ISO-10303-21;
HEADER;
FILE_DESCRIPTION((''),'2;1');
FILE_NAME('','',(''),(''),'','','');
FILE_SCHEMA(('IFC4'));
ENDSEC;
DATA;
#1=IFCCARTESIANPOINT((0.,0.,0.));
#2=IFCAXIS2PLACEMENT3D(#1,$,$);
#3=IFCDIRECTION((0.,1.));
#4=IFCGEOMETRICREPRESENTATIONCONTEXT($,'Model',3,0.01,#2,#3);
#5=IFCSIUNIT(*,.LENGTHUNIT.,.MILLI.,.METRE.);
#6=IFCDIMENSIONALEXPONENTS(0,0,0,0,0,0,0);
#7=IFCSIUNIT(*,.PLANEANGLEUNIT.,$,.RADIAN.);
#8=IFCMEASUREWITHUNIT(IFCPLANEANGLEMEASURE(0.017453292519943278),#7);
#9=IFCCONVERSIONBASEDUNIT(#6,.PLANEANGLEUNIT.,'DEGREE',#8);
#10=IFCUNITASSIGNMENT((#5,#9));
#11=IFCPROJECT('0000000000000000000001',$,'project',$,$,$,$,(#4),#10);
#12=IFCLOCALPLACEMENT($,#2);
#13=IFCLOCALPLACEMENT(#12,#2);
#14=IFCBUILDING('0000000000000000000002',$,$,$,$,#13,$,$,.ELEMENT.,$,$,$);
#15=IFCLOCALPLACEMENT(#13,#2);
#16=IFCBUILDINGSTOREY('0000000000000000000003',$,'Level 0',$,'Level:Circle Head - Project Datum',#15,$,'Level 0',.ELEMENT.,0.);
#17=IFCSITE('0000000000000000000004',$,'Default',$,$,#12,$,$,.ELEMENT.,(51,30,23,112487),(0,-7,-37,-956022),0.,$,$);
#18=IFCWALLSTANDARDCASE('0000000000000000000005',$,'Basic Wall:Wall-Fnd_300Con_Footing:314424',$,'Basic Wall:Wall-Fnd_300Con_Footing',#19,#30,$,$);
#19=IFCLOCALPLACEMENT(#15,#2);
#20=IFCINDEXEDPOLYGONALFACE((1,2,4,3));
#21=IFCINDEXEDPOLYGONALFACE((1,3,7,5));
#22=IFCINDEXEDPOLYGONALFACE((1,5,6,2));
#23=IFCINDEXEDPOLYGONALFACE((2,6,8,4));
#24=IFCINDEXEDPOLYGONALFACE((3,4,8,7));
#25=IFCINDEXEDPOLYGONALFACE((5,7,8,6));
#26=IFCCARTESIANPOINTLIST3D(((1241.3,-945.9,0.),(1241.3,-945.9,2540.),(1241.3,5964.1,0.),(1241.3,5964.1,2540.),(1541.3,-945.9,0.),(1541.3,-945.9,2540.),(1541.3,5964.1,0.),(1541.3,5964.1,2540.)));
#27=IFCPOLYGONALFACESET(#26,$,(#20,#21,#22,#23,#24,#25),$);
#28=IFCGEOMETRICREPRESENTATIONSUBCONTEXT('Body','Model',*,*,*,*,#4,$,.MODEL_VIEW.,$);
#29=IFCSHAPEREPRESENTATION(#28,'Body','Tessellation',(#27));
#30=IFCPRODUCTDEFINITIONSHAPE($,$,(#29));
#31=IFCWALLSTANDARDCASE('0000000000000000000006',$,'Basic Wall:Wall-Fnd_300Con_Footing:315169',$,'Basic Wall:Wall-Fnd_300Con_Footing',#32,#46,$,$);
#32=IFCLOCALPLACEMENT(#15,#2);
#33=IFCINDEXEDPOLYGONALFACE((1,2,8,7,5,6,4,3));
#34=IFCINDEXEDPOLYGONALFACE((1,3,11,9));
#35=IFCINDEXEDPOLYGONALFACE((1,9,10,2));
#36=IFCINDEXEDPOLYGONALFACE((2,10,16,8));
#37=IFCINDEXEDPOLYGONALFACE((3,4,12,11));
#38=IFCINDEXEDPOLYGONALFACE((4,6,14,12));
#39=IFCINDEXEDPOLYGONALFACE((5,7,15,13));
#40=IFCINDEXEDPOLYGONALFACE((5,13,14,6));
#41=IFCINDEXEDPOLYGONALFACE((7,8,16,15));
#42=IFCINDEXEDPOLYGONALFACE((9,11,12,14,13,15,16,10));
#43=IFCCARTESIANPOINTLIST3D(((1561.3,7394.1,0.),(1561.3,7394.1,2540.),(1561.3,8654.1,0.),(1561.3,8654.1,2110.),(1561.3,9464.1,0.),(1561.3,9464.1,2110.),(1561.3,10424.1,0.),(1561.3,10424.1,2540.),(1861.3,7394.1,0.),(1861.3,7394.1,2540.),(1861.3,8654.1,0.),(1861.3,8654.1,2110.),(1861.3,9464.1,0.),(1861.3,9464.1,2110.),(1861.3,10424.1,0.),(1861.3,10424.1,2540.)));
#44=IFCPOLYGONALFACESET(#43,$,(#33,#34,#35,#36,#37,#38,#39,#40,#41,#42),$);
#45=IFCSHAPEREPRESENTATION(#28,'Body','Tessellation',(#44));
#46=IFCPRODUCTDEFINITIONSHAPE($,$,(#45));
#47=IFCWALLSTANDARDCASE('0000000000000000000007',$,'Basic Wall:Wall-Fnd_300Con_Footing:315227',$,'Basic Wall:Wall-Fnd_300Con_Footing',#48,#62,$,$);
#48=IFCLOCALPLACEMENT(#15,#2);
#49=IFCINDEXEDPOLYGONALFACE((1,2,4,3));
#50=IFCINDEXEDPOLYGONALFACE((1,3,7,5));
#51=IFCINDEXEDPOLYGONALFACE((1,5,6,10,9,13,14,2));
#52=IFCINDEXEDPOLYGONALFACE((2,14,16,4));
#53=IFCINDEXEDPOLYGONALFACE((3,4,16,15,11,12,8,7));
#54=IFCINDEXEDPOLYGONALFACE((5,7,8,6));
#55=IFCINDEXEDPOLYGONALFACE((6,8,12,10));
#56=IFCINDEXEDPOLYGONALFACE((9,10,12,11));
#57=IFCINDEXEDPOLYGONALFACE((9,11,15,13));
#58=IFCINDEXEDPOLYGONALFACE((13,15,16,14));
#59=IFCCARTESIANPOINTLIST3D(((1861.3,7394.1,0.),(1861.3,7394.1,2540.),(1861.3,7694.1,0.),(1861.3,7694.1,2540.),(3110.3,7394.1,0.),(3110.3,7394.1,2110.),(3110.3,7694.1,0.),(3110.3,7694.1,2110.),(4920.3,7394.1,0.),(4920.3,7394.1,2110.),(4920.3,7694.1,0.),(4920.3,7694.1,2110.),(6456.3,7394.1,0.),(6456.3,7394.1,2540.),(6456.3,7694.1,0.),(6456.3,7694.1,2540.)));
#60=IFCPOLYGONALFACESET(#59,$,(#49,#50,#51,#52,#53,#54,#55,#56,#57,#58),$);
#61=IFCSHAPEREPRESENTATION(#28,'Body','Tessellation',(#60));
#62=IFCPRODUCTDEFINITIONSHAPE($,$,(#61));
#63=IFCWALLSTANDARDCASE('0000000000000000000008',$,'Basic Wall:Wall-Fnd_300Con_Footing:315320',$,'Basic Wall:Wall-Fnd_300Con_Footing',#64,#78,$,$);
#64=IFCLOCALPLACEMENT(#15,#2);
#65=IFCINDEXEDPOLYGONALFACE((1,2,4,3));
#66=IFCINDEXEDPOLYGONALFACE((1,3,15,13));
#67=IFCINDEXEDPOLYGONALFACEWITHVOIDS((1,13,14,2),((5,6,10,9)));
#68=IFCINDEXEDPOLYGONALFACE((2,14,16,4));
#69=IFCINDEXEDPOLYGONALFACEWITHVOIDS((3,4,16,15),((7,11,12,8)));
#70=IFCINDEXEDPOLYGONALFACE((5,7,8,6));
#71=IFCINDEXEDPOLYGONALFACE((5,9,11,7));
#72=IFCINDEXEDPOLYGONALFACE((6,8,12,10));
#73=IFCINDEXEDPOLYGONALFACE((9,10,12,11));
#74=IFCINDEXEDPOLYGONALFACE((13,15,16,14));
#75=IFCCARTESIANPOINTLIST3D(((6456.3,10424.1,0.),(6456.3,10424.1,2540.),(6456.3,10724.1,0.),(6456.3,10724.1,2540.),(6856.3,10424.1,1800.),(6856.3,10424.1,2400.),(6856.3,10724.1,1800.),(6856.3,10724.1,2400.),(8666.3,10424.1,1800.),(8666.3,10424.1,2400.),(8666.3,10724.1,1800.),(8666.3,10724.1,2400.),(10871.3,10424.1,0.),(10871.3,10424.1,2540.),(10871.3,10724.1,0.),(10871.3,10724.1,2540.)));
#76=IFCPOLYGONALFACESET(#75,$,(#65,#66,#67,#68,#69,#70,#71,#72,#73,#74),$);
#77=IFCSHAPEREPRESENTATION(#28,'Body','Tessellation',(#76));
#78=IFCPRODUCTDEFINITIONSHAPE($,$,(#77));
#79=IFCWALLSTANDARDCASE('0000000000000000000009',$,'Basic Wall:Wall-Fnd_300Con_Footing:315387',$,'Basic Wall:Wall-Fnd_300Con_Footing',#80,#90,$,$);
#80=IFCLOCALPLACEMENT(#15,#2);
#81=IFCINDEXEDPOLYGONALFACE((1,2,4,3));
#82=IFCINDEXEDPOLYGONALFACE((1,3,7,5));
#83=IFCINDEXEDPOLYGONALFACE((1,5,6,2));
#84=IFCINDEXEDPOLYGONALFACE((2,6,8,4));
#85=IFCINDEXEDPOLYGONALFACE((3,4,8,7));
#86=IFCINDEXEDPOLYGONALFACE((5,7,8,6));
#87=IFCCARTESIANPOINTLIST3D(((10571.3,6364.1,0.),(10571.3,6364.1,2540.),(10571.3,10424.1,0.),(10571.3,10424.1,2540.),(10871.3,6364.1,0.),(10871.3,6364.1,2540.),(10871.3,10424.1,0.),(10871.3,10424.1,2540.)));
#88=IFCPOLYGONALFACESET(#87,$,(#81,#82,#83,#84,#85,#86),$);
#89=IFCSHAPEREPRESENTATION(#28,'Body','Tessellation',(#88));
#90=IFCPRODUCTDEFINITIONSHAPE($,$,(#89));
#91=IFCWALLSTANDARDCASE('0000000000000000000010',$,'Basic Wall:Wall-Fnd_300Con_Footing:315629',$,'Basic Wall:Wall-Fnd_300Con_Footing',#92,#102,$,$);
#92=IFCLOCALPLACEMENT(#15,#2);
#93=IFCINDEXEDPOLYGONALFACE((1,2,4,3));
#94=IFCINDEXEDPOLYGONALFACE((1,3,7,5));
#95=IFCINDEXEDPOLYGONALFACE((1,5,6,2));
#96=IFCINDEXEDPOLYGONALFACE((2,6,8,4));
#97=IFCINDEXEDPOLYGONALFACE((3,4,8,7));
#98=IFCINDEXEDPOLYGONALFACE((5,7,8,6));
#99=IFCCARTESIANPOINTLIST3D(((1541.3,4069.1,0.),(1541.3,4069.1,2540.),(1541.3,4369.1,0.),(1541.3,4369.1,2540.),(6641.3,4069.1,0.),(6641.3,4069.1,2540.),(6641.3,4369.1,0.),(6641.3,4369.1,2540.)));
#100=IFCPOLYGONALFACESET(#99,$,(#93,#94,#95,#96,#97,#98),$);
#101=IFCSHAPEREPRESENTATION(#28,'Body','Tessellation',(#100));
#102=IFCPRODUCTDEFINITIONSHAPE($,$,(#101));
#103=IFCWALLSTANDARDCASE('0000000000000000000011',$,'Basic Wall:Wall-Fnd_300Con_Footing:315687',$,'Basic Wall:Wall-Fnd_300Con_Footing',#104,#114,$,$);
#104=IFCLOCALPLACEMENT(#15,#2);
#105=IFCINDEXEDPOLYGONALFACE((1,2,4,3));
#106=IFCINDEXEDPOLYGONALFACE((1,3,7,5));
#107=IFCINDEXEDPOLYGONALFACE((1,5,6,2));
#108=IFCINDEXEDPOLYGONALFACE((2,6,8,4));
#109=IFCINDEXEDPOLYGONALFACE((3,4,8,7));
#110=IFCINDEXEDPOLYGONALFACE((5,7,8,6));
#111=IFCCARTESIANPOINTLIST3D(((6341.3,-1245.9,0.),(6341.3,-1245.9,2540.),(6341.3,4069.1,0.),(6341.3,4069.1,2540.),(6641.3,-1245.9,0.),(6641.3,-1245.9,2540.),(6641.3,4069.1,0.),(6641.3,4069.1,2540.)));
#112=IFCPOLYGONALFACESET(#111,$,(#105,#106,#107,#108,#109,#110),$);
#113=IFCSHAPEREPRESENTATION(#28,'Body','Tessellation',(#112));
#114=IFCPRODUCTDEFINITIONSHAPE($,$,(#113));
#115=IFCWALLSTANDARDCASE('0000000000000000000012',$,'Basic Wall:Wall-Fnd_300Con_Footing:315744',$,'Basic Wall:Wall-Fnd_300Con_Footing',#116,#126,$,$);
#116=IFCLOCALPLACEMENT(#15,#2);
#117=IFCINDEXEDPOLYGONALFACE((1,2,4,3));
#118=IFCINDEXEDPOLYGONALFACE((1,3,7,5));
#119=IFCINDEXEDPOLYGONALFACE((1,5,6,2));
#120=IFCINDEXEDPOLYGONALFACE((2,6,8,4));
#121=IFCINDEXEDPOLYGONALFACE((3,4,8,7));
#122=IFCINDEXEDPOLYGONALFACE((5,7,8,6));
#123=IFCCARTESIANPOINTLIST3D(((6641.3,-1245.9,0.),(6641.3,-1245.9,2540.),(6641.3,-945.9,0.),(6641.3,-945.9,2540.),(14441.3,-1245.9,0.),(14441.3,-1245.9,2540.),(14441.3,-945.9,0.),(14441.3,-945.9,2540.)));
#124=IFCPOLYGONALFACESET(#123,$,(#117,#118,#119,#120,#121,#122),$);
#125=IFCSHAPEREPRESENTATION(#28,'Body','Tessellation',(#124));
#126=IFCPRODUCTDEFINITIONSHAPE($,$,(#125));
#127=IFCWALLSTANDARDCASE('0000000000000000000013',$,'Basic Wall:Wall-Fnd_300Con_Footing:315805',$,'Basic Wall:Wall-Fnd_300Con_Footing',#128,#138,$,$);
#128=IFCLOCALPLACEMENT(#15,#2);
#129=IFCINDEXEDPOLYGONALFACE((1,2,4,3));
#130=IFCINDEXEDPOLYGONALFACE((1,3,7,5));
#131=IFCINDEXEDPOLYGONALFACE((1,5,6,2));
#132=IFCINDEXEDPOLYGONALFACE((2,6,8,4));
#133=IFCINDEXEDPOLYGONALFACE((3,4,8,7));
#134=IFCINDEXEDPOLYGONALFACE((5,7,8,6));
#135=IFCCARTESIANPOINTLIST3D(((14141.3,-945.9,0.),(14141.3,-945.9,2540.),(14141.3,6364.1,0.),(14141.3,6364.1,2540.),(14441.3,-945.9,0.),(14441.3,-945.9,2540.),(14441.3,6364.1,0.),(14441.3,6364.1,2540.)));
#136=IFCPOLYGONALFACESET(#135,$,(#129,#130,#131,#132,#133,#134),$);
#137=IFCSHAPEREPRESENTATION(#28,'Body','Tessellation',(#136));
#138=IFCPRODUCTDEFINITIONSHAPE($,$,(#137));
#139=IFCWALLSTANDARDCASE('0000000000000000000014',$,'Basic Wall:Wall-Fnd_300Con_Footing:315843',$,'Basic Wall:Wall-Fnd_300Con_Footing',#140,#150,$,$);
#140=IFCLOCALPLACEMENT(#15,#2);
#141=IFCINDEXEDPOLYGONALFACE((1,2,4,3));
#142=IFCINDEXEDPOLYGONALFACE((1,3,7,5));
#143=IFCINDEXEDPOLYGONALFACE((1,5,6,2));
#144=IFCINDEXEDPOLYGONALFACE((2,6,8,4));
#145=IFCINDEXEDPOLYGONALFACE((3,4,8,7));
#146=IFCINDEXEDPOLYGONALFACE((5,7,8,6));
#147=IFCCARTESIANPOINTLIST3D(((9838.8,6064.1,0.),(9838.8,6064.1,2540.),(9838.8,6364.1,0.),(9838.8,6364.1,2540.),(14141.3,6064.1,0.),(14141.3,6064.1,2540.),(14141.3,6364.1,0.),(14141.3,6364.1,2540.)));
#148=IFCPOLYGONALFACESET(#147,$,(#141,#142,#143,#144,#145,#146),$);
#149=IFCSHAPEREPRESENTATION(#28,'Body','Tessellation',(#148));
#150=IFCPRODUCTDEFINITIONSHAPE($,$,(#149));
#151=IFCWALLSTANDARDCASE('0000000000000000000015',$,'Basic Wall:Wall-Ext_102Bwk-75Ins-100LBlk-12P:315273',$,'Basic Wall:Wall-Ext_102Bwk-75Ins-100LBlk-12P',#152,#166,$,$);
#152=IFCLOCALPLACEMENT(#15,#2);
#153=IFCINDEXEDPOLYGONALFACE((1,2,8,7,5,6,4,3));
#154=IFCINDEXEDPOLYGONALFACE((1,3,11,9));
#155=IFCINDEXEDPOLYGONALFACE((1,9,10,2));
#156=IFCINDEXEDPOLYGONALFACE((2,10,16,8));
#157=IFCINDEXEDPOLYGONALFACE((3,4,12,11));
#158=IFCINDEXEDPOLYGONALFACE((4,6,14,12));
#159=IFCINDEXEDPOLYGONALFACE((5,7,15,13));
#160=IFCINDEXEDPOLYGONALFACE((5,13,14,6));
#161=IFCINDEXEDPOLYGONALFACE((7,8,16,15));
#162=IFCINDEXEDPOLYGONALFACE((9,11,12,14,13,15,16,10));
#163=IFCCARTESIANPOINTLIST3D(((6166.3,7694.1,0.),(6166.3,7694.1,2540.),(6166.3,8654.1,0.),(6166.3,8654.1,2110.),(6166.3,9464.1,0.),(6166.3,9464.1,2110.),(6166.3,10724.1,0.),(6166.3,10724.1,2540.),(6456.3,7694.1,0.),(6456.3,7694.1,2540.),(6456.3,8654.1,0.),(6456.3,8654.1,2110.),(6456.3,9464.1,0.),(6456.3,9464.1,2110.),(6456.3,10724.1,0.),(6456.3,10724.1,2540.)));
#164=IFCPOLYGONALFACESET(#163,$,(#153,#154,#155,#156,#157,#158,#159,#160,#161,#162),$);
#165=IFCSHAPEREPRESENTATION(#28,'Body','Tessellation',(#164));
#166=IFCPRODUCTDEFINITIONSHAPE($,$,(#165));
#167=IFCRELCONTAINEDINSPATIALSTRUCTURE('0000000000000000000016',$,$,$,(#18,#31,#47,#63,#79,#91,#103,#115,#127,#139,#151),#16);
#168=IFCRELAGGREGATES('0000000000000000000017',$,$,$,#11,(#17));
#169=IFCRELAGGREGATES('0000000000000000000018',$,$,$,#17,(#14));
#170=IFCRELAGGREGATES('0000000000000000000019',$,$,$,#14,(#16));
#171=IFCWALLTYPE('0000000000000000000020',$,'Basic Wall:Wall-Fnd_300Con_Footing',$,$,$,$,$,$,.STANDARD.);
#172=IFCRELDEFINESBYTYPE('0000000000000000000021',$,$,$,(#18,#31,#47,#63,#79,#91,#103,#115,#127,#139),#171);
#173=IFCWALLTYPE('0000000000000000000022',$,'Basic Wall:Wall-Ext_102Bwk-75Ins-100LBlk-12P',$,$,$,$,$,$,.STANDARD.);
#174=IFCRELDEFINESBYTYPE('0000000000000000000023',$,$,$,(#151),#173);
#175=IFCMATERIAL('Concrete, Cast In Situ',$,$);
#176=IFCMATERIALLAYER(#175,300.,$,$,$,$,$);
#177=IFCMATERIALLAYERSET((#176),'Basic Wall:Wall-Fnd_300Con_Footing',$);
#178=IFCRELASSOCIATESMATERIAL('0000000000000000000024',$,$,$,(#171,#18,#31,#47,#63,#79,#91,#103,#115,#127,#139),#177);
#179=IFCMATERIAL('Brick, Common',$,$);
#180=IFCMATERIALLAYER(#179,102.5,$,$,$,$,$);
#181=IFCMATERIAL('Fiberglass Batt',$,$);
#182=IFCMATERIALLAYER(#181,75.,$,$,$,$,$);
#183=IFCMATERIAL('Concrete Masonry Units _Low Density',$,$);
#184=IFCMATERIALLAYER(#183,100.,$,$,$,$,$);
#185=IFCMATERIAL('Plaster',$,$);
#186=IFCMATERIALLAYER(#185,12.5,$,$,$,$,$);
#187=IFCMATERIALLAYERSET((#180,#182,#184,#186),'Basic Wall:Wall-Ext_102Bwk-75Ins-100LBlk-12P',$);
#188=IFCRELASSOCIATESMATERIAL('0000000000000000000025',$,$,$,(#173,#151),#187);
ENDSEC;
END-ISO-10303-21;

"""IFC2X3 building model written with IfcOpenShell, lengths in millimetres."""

from ifc_helpers import new_model, entity, si_unit, converted_unit, direction, frame, frame_2d, origin, place, context, subcontext, project, spatial, rectangle, extrude, material, layer, layer_set, layer_usage, type_object, element, save


model = new_model("IFC2X3")

# Units and contexts
model_context = context("Model", 3, precision=0.01, world=origin(), true_north=direction((0.0, 1.0)))
body_context = subcontext(model_context, "Body", "Model", "MODEL_VIEW")
ifc_project = project(units=[si_unit("LENGTHUNIT", "METRE", prefix="MILLI"), converted_unit("PLANEANGLEUNIT", "DEGREE", entity("IfcPlaneAngleMeasure", 0.017453292519943278), si_unit("PLANEANGLEUNIT", "RADIAN"), dimensions=[0, 0, 0, 0, 0, 0, 0])], contexts=[model_context])

# Site, building, storey
site_placement = place(None, origin())
site = spatial("IfcSite", under=ifc_project, at=site_placement, Name="Default", CompositionType="ELEMENT", RefLatitude=(51, 30, 23, 112487), RefLongitude=(0, -7, -37, -956022), RefElevation=0.0)
building_placement = place(site_placement, origin())
building = spatial("IfcBuilding", under=site, at=building_placement, CompositionType="ELEMENT")
storey_placement = place(building_placement, origin())
storey = spatial("IfcBuildingStorey", under=building, at=storey_placement, Name="Level 0", ObjectType="Level:Circle Head - Project Datum", LongName="Level 0", CompositionType="ELEMENT", Elevation=0.0)

# Wall
ifc_material_1 = material(Name="Concrete, Cast In Situ")
ifc_layer_1 = layer(ifc_material_1, 300.0)
ifc_layer_set_1 = layer_set([ifc_layer_1], Name="Basic Wall:Wall-Fnd_300Con_Footing")
ifc_layer_usage_1 = layer_usage(ifc_layer_set_1, "AXIS2", "NEGATIVE", 150.0)
wall_type_1 = type_object("IfcWallType", Name="Basic Wall:Wall-Fnd_300Con_Footing", PredefinedType="STANDARD", material=ifc_layer_set_1)
wall_1_placement = place(storey_placement, frame((1391.3, -945.9, 0.0), z_axis=(0.0, 0.0, 1.0), x_axis=(0.0, 1.0, 0.0)))
element("IfcWallStandardCase", 1, at=wall_1_placement, inside=storey, type_object=wall_type_1, material=ifc_layer_usage_1, Name="Basic Wall:Wall-Fnd_300Con_Footing:314424", ObjectType="Basic Wall:Wall-Fnd_300Con_Footing", context=body_context, shape_type="SweptSolid", body=[
    extrude(rectangle(XDim=6910.0, YDim=300.0, at=frame_2d((3455.0, 0.0), x_axis=(-1.0, 0.0))), origin(), (0.0, 0.0, 1.0), 2540.0),
])

# Walls, openings
wall_2_placement = place(storey_placement, frame((1711.3, 10424.1, 0.0), z_axis=(0.0, 0.0, 1.0), x_axis=(0.0, -1.0, 0.0)))
wall_2 = element("IfcWallStandardCase", 2, at=wall_2_placement, inside=storey, type_object=wall_type_1, material=ifc_layer_usage_1, Name="Basic Wall:Wall-Fnd_300Con_Footing:315169", ObjectType="Basic Wall:Wall-Fnd_300Con_Footing", context=body_context, shape_type="SweptSolid", body=[
    extrude(rectangle(XDim=3030.0, YDim=300.0, at=frame_2d((1515.0, 0.0), x_axis=(-1.0, 0.0))), origin(), (0.0, 0.0, 1.0), 2540.0),
])
opening_1_placement = place(wall_2_placement, frame((1770.0, 150.0, 0.0)))
element("IfcOpeningElement", 3, at=opening_1_placement, cuts=wall_2, ObjectType="Opening", context=body_context, shape_type="SweptSolid", body=[
    extrude(rectangle(XDim=2110.0, YDim=810.0, at=frame_2d((1055.0, 405.0), x_axis=(1.0, 0.0))), frame((0.0, 0.0, 0.0), z_axis=(0.0, -1.0, 0.0), x_axis=(0.0, 0.0, 1.0)), (0.0, 0.0, 1.0), 300.0),
])
wall_3_placement = place(storey_placement, frame((1861.3, 7544.1, 0.0)))
wall_3 = element("IfcWallStandardCase", 4, at=wall_3_placement, inside=storey, type_object=wall_type_1, material=ifc_layer_usage_1, Name="Basic Wall:Wall-Fnd_300Con_Footing:315227", ObjectType="Basic Wall:Wall-Fnd_300Con_Footing", context=body_context, shape_type="SweptSolid", body=[
    extrude(rectangle(XDim=4595.0, YDim=300.0, at=frame_2d((2297.5, 0.0), x_axis=(1.0, 0.0))), origin(), (0.0, 0.0, 1.0), 2540.0),
])
opening_2_placement = place(wall_3_placement, frame((3059.0, 150.0, 0.0)))
element("IfcOpeningElement", 5, at=opening_2_placement, cuts=wall_3, ObjectType="Opening", context=body_context, shape_type="SweptSolid", body=[
    extrude(rectangle(XDim=2110.0, YDim=1810.0, at=frame_2d((1055.0, 905.0), x_axis=(-1.0, 0.0))), frame((0.0, 0.0, 0.0), z_axis=(0.0, -1.0, 0.0), x_axis=(0.0, 0.0, 1.0)), (0.0, 0.0, 1.0), 300.0),
])
wall_4_placement = place(storey_placement, frame((6456.3, 10574.1, 0.0)))
wall_4 = element("IfcWallStandardCase", 6, at=wall_4_placement, inside=storey, type_object=wall_type_1, material=ifc_layer_usage_1, Name="Basic Wall:Wall-Fnd_300Con_Footing:315320", ObjectType="Basic Wall:Wall-Fnd_300Con_Footing", context=body_context, shape_type="SweptSolid", body=[
    extrude(rectangle(XDim=4415.0, YDim=300.0, at=frame_2d((2207.5, 0.0), x_axis=(-1.0, 0.0))), origin(), (0.0, 0.0, 1.0), 2540.0),
])
opening_3_placement = place(wall_4_placement, frame((2210.0, 150.0, 1800.0)))
element("IfcOpeningElement", 7, at=opening_3_placement, cuts=wall_4, ObjectType="Opening", context=body_context, shape_type="SweptSolid", body=[
    extrude(rectangle(XDim=600.0, YDim=1810.0, at=frame_2d((300.0, 905.0), x_axis=(-1.0, 0.0))), frame((0.0, 0.0, 0.0), z_axis=(0.0, -1.0, 0.0), x_axis=(0.0, 0.0, 1.0)), (0.0, 0.0, 1.0), 300.0),
])

# Walls
wall_5_placement = place(storey_placement, frame((10721.3, 10424.1, 0.0), z_axis=(0.0, 0.0, 1.0), x_axis=(0.0, -1.0, 0.0)))
element("IfcWallStandardCase", 8, at=wall_5_placement, inside=storey, type_object=wall_type_1, material=ifc_layer_usage_1, Name="Basic Wall:Wall-Fnd_300Con_Footing:315387", ObjectType="Basic Wall:Wall-Fnd_300Con_Footing", context=body_context, shape_type="SweptSolid", body=[
    extrude(rectangle(XDim=4060.0, YDim=300.0, at=frame_2d((2030.0, 0.0), x_axis=(-1.0, 0.0))), origin(), (0.0, 0.0, 1.0), 2540.0),
])
wall_6_placement = place(storey_placement, frame((1541.3, 4219.1, 0.0)))
element("IfcWallStandardCase", 9, at=wall_6_placement, inside=storey, type_object=wall_type_1, material=ifc_layer_usage_1, Name="Basic Wall:Wall-Fnd_300Con_Footing:315629", ObjectType="Basic Wall:Wall-Fnd_300Con_Footing", context=body_context, shape_type="SweptSolid", body=[
    extrude(rectangle(XDim=5100.0, YDim=300.0, at=frame_2d((2550.0, 0.0), x_axis=(-1.0, 0.0))), origin(), (0.0, 0.0, 1.0), 2540.0),
])
wall_7_placement = place(storey_placement, frame((6491.3, 4069.1, 0.0), z_axis=(0.0, 0.0, 1.0), x_axis=(0.0, -1.0, 0.0)))
element("IfcWallStandardCase", 10, at=wall_7_placement, inside=storey, type_object=wall_type_1, material=ifc_layer_usage_1, Name="Basic Wall:Wall-Fnd_300Con_Footing:315687", ObjectType="Basic Wall:Wall-Fnd_300Con_Footing", context=body_context, shape_type="SweptSolid", body=[
    extrude(rectangle(XDim=5315.0, YDim=300.0, at=frame_2d((2657.5, 0.0), x_axis=(-1.0, 0.0))), origin(), (0.0, 0.0, 1.0), 2540.0),
])
wall_8_placement = place(storey_placement, frame((6641.3, -1095.9, 0.0)))
element("IfcWallStandardCase", 11, at=wall_8_placement, inside=storey, type_object=wall_type_1, material=ifc_layer_usage_1, Name="Basic Wall:Wall-Fnd_300Con_Footing:315744", ObjectType="Basic Wall:Wall-Fnd_300Con_Footing", context=body_context, shape_type="SweptSolid", body=[
    extrude(rectangle(XDim=7800.0, YDim=300.0, at=frame_2d((3900.0, 0.0), x_axis=(-1.0, 0.0))), origin(), (0.0, 0.0, 1.0), 2540.0),
])
wall_9_placement = place(storey_placement, frame((14291.3, -945.9, 0.0), z_axis=(0.0, 0.0, 1.0), x_axis=(0.0, 1.0, 0.0)))
element("IfcWallStandardCase", 12, at=wall_9_placement, inside=storey, type_object=wall_type_1, material=ifc_layer_usage_1, Name="Basic Wall:Wall-Fnd_300Con_Footing:315805", ObjectType="Basic Wall:Wall-Fnd_300Con_Footing", context=body_context, shape_type="SweptSolid", body=[
    extrude(rectangle(XDim=7310.0, YDim=300.0, at=frame_2d((3655.0, 0.0), x_axis=(-1.0, 0.0))), origin(), (0.0, 0.0, 1.0), 2540.0),
])
wall_10_placement = place(storey_placement, frame((14141.3, 6214.1, 0.0), z_axis=(0.0, 0.0, 1.0), x_axis=(-1.0, 0.0, 0.0)))
element("IfcWallStandardCase", 13, at=wall_10_placement, inside=storey, type_object=wall_type_1, material=ifc_layer_usage_1, Name="Basic Wall:Wall-Fnd_300Con_Footing:315843", ObjectType="Basic Wall:Wall-Fnd_300Con_Footing", context=body_context, shape_type="SweptSolid", body=[
    extrude(rectangle(XDim=4302.5, YDim=300.0, at=frame_2d((2151.2, 0.0), x_axis=(-1.0, 0.0))), origin(), (0.0, 0.0, 1.0), 2540.0),
])

# Wall, opening
ifc_material_2 = material(Name="Brick, Common")
ifc_layer_2 = layer(ifc_material_2, 102.5)
ifc_material_3 = material(Name="Fiberglass Batt")
ifc_layer_3 = layer(ifc_material_3, 75.0)
ifc_material_4 = material(Name="Concrete Masonry Units _Low Density")
ifc_layer_4 = layer(ifc_material_4, 100.0)
ifc_material_5 = material(Name="Plaster")
ifc_layer_5 = layer(ifc_material_5, 12.5)
ifc_layer_set_2 = layer_set([ifc_layer_2, ifc_layer_3, ifc_layer_4, ifc_layer_5], Name="Basic Wall:Wall-Ext_102Bwk-75Ins-100LBlk-12P")
ifc_layer_usage_2 = layer_usage(ifc_layer_set_2, "AXIS2", "NEGATIVE", 145.0)
wall_type_2 = type_object("IfcWallType", Name="Basic Wall:Wall-Ext_102Bwk-75Ins-100LBlk-12P", PredefinedType="STANDARD", material=ifc_layer_set_2)
wall_11_placement = place(storey_placement, frame((6311.3, 7694.1, 0.0), z_axis=(0.0, 0.0, 1.0), x_axis=(0.0, 1.0, 0.0)))
wall_11 = element("IfcWallStandardCase", 14, at=wall_11_placement, inside=storey, type_object=wall_type_2, material=ifc_layer_usage_2, Name="Basic Wall:Wall-Ext_102Bwk-75Ins-100LBlk-12P:315273", ObjectType="Basic Wall:Wall-Ext_102Bwk-75Ins-100LBlk-12P", context=body_context, shape_type="SweptSolid", body=[
    extrude(rectangle(XDim=3030.0, YDim=290.0, at=frame_2d((1515.0, 0.0), x_axis=(1.0, 0.0))), origin(), (0.0, 0.0, 1.0), 2540.0),
])
opening_4_placement = place(wall_11_placement, frame((1770.0, 145.0, 0.0)))
element("IfcOpeningElement", 15, at=opening_4_placement, cuts=wall_11, ObjectType="Opening", context=body_context, shape_type="SweptSolid", body=[
    extrude(rectangle(XDim=2110.0, YDim=810.0, at=frame_2d((1055.0, 405.0), x_axis=(1.0, 0.0))), frame((0.0, 0.0, 0.0), z_axis=(0.0, -1.0, 0.0), x_axis=(0.0, 0.0, 1.0)), (0.0, 0.0, 1.0), 290.0),
])

save(model, "model.ifc")
